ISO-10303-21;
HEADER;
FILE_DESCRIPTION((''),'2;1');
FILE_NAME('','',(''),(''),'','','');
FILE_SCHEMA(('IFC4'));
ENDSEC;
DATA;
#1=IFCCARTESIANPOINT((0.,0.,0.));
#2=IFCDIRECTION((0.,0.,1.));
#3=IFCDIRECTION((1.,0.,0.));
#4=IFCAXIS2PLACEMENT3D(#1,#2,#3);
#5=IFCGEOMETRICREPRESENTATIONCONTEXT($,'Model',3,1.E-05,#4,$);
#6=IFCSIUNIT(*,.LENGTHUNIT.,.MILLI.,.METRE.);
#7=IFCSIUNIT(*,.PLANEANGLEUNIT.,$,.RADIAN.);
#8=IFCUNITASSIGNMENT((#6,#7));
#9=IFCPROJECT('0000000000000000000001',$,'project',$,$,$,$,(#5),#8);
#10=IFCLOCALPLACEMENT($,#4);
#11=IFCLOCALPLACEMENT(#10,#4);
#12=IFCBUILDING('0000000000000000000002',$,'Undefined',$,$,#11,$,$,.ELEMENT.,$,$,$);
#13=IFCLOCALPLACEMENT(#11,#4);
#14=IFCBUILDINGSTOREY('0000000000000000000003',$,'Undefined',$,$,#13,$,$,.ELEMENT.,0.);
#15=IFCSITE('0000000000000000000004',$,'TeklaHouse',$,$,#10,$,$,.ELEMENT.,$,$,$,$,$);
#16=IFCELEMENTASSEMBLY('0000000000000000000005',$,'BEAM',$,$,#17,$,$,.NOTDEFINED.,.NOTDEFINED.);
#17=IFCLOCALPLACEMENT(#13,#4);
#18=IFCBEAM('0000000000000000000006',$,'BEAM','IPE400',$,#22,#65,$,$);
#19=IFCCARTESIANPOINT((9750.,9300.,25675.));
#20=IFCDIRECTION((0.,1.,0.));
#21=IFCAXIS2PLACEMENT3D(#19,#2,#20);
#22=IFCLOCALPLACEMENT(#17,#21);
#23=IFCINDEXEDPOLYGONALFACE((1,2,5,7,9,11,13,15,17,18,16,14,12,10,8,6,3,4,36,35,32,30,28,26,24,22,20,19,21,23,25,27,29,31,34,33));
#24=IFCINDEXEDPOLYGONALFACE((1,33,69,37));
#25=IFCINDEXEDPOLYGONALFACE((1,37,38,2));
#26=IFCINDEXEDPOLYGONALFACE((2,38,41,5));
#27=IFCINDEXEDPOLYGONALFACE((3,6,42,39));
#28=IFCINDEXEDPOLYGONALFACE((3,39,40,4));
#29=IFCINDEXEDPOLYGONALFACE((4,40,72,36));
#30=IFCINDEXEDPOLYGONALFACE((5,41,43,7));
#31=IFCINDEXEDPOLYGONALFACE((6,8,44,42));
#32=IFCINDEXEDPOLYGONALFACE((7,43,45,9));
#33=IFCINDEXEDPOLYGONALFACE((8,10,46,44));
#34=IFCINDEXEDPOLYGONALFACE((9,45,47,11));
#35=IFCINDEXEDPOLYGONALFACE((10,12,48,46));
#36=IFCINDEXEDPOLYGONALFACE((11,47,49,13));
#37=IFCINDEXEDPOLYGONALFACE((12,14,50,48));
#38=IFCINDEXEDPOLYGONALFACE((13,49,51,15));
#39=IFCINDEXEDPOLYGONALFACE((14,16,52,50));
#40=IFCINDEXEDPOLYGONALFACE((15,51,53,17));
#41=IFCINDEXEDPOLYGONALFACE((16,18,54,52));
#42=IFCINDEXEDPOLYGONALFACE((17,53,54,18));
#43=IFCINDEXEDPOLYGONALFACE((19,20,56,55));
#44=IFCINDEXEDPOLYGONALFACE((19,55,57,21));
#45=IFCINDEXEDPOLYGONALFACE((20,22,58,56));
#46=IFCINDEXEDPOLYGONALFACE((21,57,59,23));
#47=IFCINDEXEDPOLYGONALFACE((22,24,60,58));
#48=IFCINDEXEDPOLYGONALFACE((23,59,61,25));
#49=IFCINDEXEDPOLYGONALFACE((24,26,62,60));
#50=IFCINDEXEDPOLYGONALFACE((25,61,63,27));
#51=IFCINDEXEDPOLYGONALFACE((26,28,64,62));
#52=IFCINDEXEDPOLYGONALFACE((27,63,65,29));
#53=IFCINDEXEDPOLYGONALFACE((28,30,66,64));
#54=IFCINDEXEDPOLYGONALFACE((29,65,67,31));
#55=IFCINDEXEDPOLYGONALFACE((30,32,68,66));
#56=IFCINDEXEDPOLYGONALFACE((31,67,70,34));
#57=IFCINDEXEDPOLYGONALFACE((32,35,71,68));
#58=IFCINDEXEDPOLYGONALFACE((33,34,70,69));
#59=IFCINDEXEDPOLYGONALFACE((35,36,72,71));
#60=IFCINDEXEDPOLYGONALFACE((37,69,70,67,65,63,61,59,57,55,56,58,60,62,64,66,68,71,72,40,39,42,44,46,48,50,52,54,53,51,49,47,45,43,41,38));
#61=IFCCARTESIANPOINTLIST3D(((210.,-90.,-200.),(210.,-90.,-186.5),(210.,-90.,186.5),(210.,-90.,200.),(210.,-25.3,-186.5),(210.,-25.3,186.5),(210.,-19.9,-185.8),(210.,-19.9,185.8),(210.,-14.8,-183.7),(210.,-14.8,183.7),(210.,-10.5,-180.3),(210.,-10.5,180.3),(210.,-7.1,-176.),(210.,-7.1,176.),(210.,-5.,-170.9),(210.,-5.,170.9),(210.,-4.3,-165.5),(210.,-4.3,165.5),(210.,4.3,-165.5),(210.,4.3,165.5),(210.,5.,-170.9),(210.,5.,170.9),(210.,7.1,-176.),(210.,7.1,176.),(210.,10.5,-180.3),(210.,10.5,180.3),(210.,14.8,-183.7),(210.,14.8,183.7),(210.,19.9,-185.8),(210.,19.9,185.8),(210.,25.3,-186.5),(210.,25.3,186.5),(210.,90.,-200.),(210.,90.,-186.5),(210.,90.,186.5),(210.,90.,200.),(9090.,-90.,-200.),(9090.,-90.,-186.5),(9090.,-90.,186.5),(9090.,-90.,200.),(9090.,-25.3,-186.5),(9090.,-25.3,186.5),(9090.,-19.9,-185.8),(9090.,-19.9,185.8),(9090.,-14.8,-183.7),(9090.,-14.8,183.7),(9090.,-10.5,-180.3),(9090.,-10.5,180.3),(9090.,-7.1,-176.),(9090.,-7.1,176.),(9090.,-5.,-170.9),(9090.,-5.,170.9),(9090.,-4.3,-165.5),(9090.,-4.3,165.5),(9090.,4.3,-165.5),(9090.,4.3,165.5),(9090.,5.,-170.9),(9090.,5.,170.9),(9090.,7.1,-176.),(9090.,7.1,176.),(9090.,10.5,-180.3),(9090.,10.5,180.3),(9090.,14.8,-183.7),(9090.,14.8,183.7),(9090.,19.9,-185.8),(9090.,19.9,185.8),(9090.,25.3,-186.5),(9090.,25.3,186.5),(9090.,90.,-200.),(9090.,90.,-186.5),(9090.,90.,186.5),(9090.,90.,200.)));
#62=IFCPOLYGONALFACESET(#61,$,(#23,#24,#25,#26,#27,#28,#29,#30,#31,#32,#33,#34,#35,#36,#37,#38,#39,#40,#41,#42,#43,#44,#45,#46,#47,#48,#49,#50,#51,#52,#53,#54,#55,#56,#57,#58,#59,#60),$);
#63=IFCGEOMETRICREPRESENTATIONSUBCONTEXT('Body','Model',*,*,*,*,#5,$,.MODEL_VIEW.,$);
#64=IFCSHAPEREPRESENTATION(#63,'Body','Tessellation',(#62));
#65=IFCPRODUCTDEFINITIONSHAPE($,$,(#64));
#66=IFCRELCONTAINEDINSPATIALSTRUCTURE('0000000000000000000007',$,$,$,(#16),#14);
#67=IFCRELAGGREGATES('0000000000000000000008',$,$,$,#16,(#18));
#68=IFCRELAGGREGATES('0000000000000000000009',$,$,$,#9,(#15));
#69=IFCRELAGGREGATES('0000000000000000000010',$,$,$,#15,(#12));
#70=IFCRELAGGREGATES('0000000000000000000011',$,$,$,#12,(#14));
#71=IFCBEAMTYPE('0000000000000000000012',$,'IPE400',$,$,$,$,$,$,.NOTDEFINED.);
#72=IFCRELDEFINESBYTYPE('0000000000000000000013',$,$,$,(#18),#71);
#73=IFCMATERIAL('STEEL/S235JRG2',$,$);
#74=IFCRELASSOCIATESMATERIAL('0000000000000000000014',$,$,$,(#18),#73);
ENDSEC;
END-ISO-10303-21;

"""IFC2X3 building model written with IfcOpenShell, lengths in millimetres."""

from ifc_helpers import new_model, si_unit, frame, origin_with_axes, origin_2d_with_axis, place, context, subcontext, project, spatial, i_section, extrude, clip, halfspace, material, type_object, element, aggregate, save


model = new_model("IFC2X3")

# Units and contexts
model_context = context("Model", 3, precision=1e-05, world=origin_with_axes())
body_context = subcontext(model_context, "Body", "Model", "MODEL_VIEW")
ifc_project = project(units=[si_unit("LENGTHUNIT", "METRE", prefix="MILLI"), si_unit("PLANEANGLEUNIT", "RADIAN")], contexts=[model_context])

# Site, building, storey
site_placement = place(None, origin_with_axes())
site = spatial("IfcSite", under=ifc_project, at=site_placement, Name="TeklaHouse", CompositionType="ELEMENT")
building_placement = place(site_placement, origin_with_axes())
building = spatial("IfcBuilding", under=site, at=building_placement, Name="Undefined", CompositionType="ELEMENT")
storey_placement = place(building_placement, origin_with_axes())
storey = spatial("IfcBuildingStorey", under=building, at=storey_placement, Name="Undefined", CompositionType="ELEMENT", Elevation=0.0)

# Shared definitions
ifc_material_1 = material(Name="STEEL/S235JRG2")

# Element assembly
assembly_1_placement = place(storey_placement, origin_with_axes())
assembly_1 = element("IfcElementAssembly", 1, at=assembly_1_placement, inside=storey, Name="BEAM", AssemblyPlace="NOTDEFINED", PredefinedType="NOTDEFINED")

# Beam
beam_type_1 = type_object("IfcBeamType", Name="IPE400", PredefinedType="NOTDEFINED")
beam_1_placement = place(assembly_1_placement, frame((9750.0, 9300.0, 25675.0), z_axis=(0.0, 0.0, 1.0), x_axis=(0.0, 1.0, 0.0)))
beam_1 = element("IfcBeam", 2, at=beam_1_placement, type_object=beam_type_1, material=ifc_material_1, Name="BEAM", Description="IPE400", context=body_context, shape_type="Clipping", body=[
    clip(clip(extrude(i_section(OverallWidth=180.0, OverallDepth=400.0, WebThickness=8.6, FlangeThickness=13.5, FilletRadius=21.0, at=origin_2d_with_axis()), frame((9300.0, 0.0, 0.0), z_axis=(-1.0, 0.0, 0.0), x_axis=(0.0, -1.0, 0.0)), (0.0, 0.0, 1.0), 9300.0), halfspace(frame((9090.0, 0.0, -200.0), z_axis=(-1.0, 0.0, 0.0), x_axis=(0.0, 1.0, 0.0)), True)), halfspace(frame((210.0, 0.0, -200.0), z_axis=(1.0, 0.0, 0.0), x_axis=(0.0, -1.0, 0.0)), True)),
])

aggregate(assembly_1, [beam_1])

save(model, "model.ifc")
